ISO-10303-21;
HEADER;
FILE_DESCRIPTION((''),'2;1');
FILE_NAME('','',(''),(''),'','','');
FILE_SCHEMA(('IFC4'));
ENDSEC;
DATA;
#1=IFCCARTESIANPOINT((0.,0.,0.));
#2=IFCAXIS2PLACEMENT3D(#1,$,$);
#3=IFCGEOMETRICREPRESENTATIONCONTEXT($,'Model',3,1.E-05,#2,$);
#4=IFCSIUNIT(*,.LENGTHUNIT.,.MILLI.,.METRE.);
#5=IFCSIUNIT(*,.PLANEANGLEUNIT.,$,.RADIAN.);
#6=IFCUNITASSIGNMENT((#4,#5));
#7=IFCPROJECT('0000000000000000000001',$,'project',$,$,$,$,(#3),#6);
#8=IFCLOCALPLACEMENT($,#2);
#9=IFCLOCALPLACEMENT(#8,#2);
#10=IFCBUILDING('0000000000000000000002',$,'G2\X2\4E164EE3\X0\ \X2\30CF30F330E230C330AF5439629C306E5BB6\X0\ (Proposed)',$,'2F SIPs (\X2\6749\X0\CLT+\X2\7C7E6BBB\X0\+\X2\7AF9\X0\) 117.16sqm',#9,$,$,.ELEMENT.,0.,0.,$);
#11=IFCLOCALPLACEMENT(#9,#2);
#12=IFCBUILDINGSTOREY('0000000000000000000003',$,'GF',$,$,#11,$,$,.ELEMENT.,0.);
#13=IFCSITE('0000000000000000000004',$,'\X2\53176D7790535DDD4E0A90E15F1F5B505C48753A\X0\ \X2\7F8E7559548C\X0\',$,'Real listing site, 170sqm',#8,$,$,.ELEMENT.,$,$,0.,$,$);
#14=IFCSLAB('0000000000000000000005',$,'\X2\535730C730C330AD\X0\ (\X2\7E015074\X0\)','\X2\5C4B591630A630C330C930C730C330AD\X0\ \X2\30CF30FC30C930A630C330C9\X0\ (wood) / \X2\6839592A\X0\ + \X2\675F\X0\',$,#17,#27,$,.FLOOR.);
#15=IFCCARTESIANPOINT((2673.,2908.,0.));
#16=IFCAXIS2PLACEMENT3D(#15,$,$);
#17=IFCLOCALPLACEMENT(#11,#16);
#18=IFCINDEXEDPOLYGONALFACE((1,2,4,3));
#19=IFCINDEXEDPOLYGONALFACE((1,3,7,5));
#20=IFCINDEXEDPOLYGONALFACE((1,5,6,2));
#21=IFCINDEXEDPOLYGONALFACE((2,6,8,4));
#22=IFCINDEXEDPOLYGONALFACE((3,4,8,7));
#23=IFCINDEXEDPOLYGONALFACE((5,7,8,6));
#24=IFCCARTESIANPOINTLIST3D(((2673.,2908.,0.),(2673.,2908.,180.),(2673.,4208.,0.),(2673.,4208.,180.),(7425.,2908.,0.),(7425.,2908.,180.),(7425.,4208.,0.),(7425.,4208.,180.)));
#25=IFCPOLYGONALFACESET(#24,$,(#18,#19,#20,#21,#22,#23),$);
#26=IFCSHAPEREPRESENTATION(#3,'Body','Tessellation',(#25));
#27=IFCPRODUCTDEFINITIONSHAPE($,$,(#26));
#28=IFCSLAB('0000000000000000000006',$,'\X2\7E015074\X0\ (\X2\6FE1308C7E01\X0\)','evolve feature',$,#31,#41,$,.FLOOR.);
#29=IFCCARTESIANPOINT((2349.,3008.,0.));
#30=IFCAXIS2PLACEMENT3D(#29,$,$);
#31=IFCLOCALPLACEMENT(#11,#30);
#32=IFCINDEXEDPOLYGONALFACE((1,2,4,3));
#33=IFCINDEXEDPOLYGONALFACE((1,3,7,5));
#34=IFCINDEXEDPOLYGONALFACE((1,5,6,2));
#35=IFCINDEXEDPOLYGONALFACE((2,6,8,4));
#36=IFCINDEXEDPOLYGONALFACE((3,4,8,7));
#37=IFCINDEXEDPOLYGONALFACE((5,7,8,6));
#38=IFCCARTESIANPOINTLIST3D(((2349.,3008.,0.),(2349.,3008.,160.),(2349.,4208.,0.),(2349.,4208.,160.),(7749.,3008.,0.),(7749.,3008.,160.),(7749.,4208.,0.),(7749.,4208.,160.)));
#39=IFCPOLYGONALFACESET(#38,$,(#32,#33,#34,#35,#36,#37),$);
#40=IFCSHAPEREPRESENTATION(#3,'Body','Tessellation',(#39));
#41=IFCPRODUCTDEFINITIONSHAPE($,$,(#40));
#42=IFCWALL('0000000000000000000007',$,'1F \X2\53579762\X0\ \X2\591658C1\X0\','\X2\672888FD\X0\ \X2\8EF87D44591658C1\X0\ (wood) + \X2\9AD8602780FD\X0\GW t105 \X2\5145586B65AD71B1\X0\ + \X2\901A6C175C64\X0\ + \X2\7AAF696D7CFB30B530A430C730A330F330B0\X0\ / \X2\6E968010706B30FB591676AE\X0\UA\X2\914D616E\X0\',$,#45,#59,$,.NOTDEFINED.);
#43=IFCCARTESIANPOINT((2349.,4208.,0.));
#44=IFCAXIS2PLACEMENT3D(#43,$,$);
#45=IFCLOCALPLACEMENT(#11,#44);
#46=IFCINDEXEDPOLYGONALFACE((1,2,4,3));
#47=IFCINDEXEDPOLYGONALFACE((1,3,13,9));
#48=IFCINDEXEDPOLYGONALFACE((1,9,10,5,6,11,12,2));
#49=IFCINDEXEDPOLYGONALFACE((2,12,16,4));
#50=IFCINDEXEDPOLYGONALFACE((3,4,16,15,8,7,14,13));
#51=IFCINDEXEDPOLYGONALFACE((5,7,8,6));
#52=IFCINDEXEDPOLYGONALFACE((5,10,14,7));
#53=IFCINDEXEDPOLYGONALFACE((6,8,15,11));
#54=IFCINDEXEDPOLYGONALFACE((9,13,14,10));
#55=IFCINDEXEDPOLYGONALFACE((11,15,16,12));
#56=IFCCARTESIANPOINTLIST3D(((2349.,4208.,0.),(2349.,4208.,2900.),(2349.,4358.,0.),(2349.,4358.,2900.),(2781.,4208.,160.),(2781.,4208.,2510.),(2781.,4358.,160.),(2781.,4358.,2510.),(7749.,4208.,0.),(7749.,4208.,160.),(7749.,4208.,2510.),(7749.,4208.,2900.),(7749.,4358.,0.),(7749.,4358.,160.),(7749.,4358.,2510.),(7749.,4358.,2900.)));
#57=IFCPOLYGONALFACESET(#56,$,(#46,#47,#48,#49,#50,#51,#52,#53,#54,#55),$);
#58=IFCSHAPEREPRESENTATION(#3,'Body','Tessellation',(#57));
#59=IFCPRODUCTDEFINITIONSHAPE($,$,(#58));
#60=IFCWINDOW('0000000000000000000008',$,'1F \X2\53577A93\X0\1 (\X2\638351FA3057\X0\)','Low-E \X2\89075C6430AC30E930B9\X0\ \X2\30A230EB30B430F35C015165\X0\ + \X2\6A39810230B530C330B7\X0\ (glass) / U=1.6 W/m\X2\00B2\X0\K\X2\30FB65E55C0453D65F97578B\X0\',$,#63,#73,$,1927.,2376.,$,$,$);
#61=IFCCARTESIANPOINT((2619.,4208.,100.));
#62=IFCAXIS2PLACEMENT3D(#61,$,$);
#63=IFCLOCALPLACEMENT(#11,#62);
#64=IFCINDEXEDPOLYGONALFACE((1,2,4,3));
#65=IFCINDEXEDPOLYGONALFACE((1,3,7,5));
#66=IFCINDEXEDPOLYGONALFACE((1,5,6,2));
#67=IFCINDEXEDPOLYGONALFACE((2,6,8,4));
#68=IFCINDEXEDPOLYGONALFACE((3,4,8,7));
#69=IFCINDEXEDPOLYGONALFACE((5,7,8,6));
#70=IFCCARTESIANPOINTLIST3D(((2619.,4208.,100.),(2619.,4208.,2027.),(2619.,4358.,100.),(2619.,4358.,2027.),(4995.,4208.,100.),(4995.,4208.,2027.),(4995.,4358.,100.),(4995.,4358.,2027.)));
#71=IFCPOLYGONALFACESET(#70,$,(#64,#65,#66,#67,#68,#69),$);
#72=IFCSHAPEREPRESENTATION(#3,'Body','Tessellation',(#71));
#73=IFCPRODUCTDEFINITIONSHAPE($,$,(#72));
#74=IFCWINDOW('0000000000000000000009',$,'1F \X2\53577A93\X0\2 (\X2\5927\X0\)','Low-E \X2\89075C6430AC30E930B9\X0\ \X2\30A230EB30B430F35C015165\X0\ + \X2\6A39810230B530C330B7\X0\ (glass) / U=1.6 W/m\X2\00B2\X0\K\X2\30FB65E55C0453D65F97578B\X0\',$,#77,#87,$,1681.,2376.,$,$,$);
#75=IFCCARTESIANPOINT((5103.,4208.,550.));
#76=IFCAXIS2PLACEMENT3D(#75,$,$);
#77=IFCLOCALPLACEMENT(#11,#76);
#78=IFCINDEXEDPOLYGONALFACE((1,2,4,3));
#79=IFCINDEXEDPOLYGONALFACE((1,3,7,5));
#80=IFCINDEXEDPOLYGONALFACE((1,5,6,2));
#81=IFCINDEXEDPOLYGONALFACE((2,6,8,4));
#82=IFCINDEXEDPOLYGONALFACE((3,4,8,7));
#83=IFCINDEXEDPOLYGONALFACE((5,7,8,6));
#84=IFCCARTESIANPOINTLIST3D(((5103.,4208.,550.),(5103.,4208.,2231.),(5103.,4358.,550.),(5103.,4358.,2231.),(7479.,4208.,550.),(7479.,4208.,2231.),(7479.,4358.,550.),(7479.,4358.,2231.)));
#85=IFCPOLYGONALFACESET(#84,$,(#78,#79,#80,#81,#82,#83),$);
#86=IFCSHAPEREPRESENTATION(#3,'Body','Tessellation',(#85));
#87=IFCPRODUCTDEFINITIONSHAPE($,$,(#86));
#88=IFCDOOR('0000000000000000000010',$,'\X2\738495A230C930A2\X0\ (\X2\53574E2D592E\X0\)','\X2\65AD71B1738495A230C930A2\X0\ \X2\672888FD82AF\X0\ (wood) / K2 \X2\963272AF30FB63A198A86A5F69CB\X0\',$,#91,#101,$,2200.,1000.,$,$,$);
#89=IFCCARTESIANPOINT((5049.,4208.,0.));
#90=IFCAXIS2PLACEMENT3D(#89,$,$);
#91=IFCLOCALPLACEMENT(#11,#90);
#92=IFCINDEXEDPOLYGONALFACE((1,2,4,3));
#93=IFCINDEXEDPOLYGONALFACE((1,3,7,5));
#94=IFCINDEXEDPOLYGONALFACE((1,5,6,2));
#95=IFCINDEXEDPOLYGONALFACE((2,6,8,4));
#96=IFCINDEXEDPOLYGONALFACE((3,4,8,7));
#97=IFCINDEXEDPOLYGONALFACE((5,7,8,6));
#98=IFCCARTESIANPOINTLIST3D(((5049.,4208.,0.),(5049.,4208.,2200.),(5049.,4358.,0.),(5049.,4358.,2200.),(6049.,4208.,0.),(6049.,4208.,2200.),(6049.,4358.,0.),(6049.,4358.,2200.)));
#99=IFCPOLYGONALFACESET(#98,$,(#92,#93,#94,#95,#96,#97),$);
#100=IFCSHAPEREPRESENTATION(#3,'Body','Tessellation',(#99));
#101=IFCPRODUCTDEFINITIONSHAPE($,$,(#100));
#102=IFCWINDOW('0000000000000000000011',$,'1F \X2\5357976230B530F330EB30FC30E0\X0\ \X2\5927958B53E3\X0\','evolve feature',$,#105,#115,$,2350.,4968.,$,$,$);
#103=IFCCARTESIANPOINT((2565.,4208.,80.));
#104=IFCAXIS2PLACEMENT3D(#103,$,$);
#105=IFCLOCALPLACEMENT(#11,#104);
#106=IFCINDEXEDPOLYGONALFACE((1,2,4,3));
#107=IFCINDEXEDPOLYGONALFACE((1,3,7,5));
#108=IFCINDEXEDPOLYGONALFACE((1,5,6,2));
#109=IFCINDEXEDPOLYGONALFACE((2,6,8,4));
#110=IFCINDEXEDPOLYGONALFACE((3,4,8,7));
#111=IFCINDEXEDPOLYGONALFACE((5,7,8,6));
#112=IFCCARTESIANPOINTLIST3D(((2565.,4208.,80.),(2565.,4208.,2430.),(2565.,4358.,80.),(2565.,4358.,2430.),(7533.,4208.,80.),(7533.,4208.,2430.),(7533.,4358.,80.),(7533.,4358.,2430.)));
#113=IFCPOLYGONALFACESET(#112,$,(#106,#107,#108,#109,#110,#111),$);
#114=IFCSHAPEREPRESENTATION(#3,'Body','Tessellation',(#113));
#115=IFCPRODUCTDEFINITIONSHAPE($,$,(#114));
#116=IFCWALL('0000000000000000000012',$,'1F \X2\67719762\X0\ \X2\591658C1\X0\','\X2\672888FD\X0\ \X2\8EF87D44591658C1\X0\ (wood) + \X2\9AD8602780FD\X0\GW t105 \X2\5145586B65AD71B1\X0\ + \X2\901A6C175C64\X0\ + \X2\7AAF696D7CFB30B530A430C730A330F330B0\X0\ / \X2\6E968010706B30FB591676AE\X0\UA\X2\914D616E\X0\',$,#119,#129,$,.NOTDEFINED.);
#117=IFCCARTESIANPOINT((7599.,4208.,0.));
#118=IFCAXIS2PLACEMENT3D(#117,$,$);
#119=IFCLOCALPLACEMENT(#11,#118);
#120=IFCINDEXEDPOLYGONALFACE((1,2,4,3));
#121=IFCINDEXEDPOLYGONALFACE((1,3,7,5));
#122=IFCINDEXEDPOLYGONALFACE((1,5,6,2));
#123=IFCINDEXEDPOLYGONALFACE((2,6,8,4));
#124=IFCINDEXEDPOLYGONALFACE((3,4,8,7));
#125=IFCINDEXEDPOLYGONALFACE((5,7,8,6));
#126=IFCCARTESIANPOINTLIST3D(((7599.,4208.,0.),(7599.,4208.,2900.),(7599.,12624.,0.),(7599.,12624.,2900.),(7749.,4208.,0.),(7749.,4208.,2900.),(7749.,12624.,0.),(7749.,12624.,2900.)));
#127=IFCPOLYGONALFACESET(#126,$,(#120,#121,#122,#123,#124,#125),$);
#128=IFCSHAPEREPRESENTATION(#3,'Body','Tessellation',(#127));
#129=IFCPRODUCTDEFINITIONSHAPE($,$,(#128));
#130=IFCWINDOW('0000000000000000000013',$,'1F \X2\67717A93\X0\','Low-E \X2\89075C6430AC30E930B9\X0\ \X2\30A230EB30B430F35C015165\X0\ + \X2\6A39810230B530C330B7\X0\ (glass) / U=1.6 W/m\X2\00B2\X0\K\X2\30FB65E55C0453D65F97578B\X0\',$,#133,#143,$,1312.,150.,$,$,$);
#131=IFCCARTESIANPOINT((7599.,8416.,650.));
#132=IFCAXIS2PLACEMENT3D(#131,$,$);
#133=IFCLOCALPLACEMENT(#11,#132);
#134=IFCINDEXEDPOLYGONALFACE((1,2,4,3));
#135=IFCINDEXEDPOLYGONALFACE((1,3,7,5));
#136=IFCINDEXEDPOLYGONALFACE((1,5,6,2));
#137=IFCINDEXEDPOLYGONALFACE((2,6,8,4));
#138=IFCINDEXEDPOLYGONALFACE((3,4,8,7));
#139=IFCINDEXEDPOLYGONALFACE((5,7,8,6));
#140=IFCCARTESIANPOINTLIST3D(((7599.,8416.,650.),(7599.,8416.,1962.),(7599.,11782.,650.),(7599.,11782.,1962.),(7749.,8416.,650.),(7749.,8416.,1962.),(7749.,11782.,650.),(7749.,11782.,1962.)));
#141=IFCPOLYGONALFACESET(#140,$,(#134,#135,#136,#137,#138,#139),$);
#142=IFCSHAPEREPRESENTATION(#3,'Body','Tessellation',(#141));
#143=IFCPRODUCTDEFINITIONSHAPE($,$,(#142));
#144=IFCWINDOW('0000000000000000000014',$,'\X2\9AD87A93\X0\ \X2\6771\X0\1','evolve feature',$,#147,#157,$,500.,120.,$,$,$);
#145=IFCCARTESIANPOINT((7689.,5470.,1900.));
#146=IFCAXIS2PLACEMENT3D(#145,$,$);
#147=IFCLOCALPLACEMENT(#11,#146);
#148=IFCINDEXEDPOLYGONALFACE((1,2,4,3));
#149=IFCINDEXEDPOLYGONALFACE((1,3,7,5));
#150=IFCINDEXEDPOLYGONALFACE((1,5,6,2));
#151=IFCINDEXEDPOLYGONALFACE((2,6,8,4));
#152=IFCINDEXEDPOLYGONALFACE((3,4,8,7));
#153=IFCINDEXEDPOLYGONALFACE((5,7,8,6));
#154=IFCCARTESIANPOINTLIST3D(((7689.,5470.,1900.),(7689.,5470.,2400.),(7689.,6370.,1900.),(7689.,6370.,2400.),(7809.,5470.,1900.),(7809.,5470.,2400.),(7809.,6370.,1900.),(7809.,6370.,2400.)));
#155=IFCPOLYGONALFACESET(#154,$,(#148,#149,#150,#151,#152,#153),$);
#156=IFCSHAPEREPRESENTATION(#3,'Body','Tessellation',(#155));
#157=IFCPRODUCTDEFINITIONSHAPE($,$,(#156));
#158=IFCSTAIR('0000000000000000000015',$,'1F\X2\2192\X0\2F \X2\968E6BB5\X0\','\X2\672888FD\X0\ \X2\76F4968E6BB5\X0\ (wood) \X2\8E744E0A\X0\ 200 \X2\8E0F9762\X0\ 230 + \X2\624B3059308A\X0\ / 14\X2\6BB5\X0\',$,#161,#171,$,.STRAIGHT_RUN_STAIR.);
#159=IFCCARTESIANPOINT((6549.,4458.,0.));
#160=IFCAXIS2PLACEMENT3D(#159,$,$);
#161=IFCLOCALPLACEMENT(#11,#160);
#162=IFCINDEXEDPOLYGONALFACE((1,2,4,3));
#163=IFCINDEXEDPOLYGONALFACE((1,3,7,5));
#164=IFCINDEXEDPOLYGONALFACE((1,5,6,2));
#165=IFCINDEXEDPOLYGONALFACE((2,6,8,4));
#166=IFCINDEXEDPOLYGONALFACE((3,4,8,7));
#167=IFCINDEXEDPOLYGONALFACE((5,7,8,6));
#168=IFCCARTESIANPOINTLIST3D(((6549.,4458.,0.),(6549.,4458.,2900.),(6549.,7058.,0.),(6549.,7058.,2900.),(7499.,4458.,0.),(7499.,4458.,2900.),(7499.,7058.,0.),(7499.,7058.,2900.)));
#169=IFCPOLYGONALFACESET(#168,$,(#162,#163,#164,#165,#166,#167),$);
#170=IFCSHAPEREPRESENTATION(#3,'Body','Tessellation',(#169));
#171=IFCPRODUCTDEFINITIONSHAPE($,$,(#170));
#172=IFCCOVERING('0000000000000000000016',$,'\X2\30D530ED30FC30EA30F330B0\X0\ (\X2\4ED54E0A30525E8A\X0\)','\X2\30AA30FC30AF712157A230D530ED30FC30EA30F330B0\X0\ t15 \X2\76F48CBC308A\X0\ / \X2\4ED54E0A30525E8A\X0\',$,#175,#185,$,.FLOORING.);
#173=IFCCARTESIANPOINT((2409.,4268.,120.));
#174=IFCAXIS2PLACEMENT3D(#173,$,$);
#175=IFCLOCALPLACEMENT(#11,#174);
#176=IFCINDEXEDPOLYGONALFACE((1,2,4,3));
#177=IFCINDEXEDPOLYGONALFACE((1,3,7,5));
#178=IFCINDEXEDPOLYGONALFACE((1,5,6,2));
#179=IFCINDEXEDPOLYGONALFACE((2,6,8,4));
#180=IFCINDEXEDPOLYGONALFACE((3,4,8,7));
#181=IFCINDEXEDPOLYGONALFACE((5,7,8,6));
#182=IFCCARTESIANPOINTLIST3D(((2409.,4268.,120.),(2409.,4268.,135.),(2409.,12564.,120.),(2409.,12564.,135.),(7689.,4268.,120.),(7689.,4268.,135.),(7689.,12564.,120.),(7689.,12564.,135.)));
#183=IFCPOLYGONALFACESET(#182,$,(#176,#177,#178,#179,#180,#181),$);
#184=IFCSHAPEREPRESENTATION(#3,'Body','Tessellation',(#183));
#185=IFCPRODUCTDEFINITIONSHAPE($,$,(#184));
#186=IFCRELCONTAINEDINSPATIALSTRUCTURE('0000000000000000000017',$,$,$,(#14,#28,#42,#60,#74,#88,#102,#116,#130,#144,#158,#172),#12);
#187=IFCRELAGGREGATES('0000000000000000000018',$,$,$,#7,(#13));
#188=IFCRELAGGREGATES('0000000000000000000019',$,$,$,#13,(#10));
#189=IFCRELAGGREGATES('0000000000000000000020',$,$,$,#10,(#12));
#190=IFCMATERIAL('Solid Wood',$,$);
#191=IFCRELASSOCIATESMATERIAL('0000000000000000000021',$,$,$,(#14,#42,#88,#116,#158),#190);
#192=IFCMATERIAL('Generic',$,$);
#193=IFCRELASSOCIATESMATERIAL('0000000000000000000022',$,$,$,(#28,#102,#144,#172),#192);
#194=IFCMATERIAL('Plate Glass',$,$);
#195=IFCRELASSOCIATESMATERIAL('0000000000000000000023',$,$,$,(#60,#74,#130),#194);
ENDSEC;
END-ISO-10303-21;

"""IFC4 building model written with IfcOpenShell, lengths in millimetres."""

from ifc_helpers import new_model, si_unit, frame, frame_2d, origin, place, context, project, spatial, rectangle, extrude, material, element, fill, save


model = new_model("IFC4")

# Units and contexts
model_context = context("Model", 3, precision=1e-05, world=origin())
ifc_project = project(units=[si_unit("LENGTHUNIT", "METRE", prefix="MILLI"), si_unit("PLANEANGLEUNIT", "RADIAN")], contexts=[model_context])

# Site, building, storey
site_placement = place(None, origin())
site = spatial("IfcSite", under=ifc_project, at=site_placement, Name="北海道川上郡弟子屈町 美留和", ObjectType="Real listing site, 170sqm", CompositionType="ELEMENT", RefElevation=0.0)
building_placement = place(site_placement, origin())
building = spatial("IfcBuilding", under=site, at=building_placement, Name="G2世代 ハンモック吹抜の家 (Proposed)", ObjectType="2F SIPs (杉CLT+籾殻+竹) 117.16sqm", CompositionType="ELEMENT", ElevationOfRefHeight=0.0, ElevationOfTerrain=0.0)
storey_placement = place(building_placement, origin())
storey = spatial("IfcBuildingStorey", under=building, at=storey_placement, Name="GF", CompositionType="ELEMENT", Elevation=0.0)

# Slabs
ifc_material_1 = material(Name="Solid Wood")
slab_1_placement = place(storey_placement, frame((2673.0, 2908.0, 0.0)))
element("IfcSlab", 1, at=slab_1_placement, inside=storey, material=ifc_material_1, Name="南デッキ (縁側)", Description="屋外ウッドデッキ ハードウッド (wood) / 根太 + 束", PredefinedType="FLOOR", context=model_context, shape_type="SweptSolid", body=[
    extrude(rectangle(XDim=4752.0, YDim=1300.0, at=frame_2d((2376.0, 650.0))), frame((2673.0, 2908.0, 0.0)), (0.0, 0.0, 1.0), 180.0),
])
ifc_material_2 = material(Name="Generic")
slab_2_placement = place(storey_placement, frame((2349.0, 3008.0, 0.0)))
element("IfcSlab", 2, at=slab_2_placement, inside=storey, material=ifc_material_2, Name="縁側 (濡れ縁)", Description="evolve feature", PredefinedType="FLOOR", context=model_context, shape_type="SweptSolid", body=[
    extrude(rectangle(XDim=5400.0, YDim=1200.0, at=frame_2d((2700.0, 600.0))), frame((2349.0, 3008.0, 0.0)), (0.0, 0.0, 1.0), 160.0),
])

# Wall, openings, windows, door
wall_1_placement = place(storey_placement, frame((2349.0, 4208.0, 0.0)))
wall_1 = element("IfcWall", 3, at=wall_1_placement, inside=storey, material=ifc_material_1, Name="1F 南面 外壁", Description="木製 軸組外壁 (wood) + 高性能GW t105 充填断熱 + 通気層 + 窯業系サイディング / 準耐火・外皮UA配慮", PredefinedType="NOTDEFINED", context=model_context, shape_type="SweptSolid", body=[
    extrude(rectangle(XDim=5400.0, YDim=150.0, at=frame_2d((2700.0, 75.0))), frame((2349.0, 4208.0, 0.0)), (0.0, 0.0, 1.0), 2900.0),
])
opening_1_placement = place(storey_placement, frame((2619.0, 4208.0, 100.0)))
opening_1 = element("IfcOpeningElement", 4, at=opening_1_placement, cuts=wall_1, PredefinedType="NOTDEFINED", context=model_context, shape_type="SweptSolid", body=[
    extrude(rectangle(XDim=2376.0, YDim=150.0, at=frame_2d((1188.0, 75.0))), frame((2619.0, 4208.0, 100.0)), (0.0, 0.0, 1.0), 1927.0),
])
opening_2_placement = place(storey_placement, frame((5103.0, 4208.0, 550.0)))
opening_2 = element("IfcOpeningElement", 5, at=opening_2_placement, cuts=wall_1, PredefinedType="NOTDEFINED", context=model_context, shape_type="SweptSolid", body=[
    extrude(rectangle(XDim=2376.0, YDim=150.0, at=frame_2d((1188.0, 75.0))), frame((5103.0, 4208.0, 550.0)), (0.0, 0.0, 1.0), 1681.0),
])
opening_3_placement = place(storey_placement, frame((5049.0, 4208.0, 0.0)))
opening_3 = element("IfcOpeningElement", 6, at=opening_3_placement, cuts=wall_1, PredefinedType="NOTDEFINED", context=model_context, shape_type="SweptSolid", body=[
    extrude(rectangle(XDim=1000.0, YDim=150.0, at=frame_2d((500.0, 75.0))), frame((5049.0, 4208.0, 0.0)), (0.0, 0.0, 1.0), 2200.0),
])
opening_4_placement = place(storey_placement, frame((2565.0, 4208.0, 80.0)))
opening_4 = element("IfcOpeningElement", 7, at=opening_4_placement, cuts=wall_1, PredefinedType="NOTDEFINED", context=model_context, shape_type="SweptSolid", body=[
    extrude(rectangle(XDim=4968.0, YDim=150.0, at=frame_2d((2484.0, 75.0))), frame((2565.0, 4208.0, 80.0)), (0.0, 0.0, 1.0), 2350.0),
])
ifc_material_3 = material(Name="Plate Glass")
window_1_placement = place(storey_placement, frame((2619.0, 4208.0, 100.0)))
window_1 = element("IfcWindow", 8, at=window_1_placement, inside=storey, material=ifc_material_3, Name="1F 南窓1 (掃出し)", Description="Low-E 複層ガラス アルゴン封入 + 樹脂サッシ (glass) / U=1.6 W/m²K・日射取得型", OverallHeight=1927.0, OverallWidth=2376.0, context=model_context, shape_type="SweptSolid", body=[
    extrude(rectangle(XDim=2376.0, YDim=150.0, at=frame_2d((1188.0, 75.0))), frame((2619.0, 4208.0, 100.0)), (0.0, 0.0, 1.0), 1927.0),
])
fill(opening_1, window_1)
window_2_placement = place(storey_placement, frame((5103.0, 4208.0, 550.0)))
window_2 = element("IfcWindow", 9, at=window_2_placement, inside=storey, material=ifc_material_3, Name="1F 南窓2 (大)", Description="Low-E 複層ガラス アルゴン封入 + 樹脂サッシ (glass) / U=1.6 W/m²K・日射取得型", OverallHeight=1681.0, OverallWidth=2376.0, context=model_context, shape_type="SweptSolid", body=[
    extrude(rectangle(XDim=2376.0, YDim=150.0, at=frame_2d((1188.0, 75.0))), frame((5103.0, 4208.0, 550.0)), (0.0, 0.0, 1.0), 1681.0),
])
fill(opening_2, window_2)
door_placement = place(storey_placement, frame((5049.0, 4208.0, 0.0)))
door = element("IfcDoor", 10, at=door_placement, inside=storey, material=ifc_material_1, Name="玄関ドア (南中央)", Description="断熱玄関ドア 木製芯 (wood) / K2 防犯・採風機構", OverallHeight=2200.0, OverallWidth=1000.0, context=model_context, shape_type="SweptSolid", body=[
    extrude(rectangle(XDim=1000.0, YDim=150.0, at=frame_2d((500.0, 75.0))), frame((5049.0, 4208.0, 0.0)), (0.0, 0.0, 1.0), 2200.0),
])
fill(opening_3, door)
window_3_placement = place(storey_placement, frame((2565.0, 4208.0, 80.0)))
window_3 = element("IfcWindow", 11, at=window_3_placement, inside=storey, material=ifc_material_2, Name="1F 南面サンルーム 大開口", Description="evolve feature", OverallHeight=2350.0, OverallWidth=4968.0, context=model_context, shape_type="SweptSolid", body=[
    extrude(rectangle(XDim=4968.0, YDim=150.0, at=frame_2d((2484.0, 75.0))), frame((2565.0, 4208.0, 80.0)), (0.0, 0.0, 1.0), 2350.0),
])
fill(opening_4, window_3)

# Wall, openings, windows
wall_2_placement = place(storey_placement, frame((7599.0, 4208.0, 0.0)))
wall_2 = element("IfcWall", 12, at=wall_2_placement, inside=storey, material=ifc_material_1, Name="1F 東面 外壁", Description="木製 軸組外壁 (wood) + 高性能GW t105 充填断熱 + 通気層 + 窯業系サイディング / 準耐火・外皮UA配慮", PredefinedType="NOTDEFINED", context=model_context, shape_type="SweptSolid", body=[
    extrude(rectangle(XDim=150.0, YDim=8416.0, at=frame_2d((75.0, 4208.0))), frame((7599.0, 4208.0, 0.0)), (0.0, 0.0, 1.0), 2900.0),
])
opening_5_placement = place(storey_placement, frame((7599.0, 8416.0, 650.0)))
opening_5 = element("IfcOpeningElement", 13, at=opening_5_placement, cuts=wall_2, PredefinedType="NOTDEFINED", context=model_context, shape_type="SweptSolid", body=[
    extrude(rectangle(XDim=150.0, YDim=3366.0, at=frame_2d((75.0, 1683.0))), frame((7599.0, 8416.0, 650.0)), (0.0, 0.0, 1.0), 1312.0),
])
opening_6_placement = place(storey_placement, frame((7689.0, 5470.0, 1900.0)))
opening_6 = element("IfcOpeningElement", 14, at=opening_6_placement, cuts=wall_2, PredefinedType="NOTDEFINED", context=model_context, shape_type="SweptSolid", body=[
    extrude(rectangle(XDim=120.0, YDim=900.0, at=frame_2d((60.0, 450.0))), frame((7689.0, 5470.0, 1900.0)), (0.0, 0.0, 1.0), 500.0),
])
window_4_placement = place(storey_placement, frame((7599.0, 8416.0, 650.0)))
window_4 = element("IfcWindow", 15, at=window_4_placement, inside=storey, material=ifc_material_3, Name="1F 東窓", Description="Low-E 複層ガラス アルゴン封入 + 樹脂サッシ (glass) / U=1.6 W/m²K・日射取得型", OverallHeight=1312.0, OverallWidth=150.0, context=model_context, shape_type="SweptSolid", body=[
    extrude(rectangle(XDim=150.0, YDim=3366.0, at=frame_2d((75.0, 1683.0))), frame((7599.0, 8416.0, 650.0)), (0.0, 0.0, 1.0), 1312.0),
])
fill(opening_5, window_4)
window_5_placement = place(storey_placement, frame((7689.0, 5470.0, 1900.0)))
window_5 = element("IfcWindow", 16, at=window_5_placement, inside=storey, material=ifc_material_2, Name="高窓 東1", Description="evolve feature", OverallHeight=500.0, OverallWidth=120.0, context=model_context, shape_type="SweptSolid", body=[
    extrude(rectangle(XDim=120.0, YDim=900.0, at=frame_2d((60.0, 450.0))), frame((7689.0, 5470.0, 1900.0)), (0.0, 0.0, 1.0), 500.0),
])
fill(opening_6, window_5)

# Stair
stair_placement = place(storey_placement, frame((6549.0, 4458.0, 0.0)))
element("IfcStair", 17, at=stair_placement, inside=storey, material=ifc_material_1, Name="1F→2F 階段", Description="木製 直階段 (wood) 蹴上 200 踏面 230 + 手すり / 14段", PredefinedType="STRAIGHT_RUN_STAIR", context=model_context, shape_type="SweptSolid", body=[
    extrude(rectangle(XDim=950.0, YDim=2600.0, at=frame_2d((475.0, 1300.0))), frame((6549.0, 4458.0, 0.0)), (0.0, 0.0, 1.0), 2900.0),
])

# Covering
covering_placement = place(storey_placement, frame((2409.0, 4268.0, 120.0)))
element("IfcCovering", 18, at=covering_placement, inside=storey, material=ifc_material_2, Name="フローリング (仕上げ床)", Description="オーク無垢フローリング t15 直貼り / 仕上げ床", PredefinedType="FLOORING", context=model_context, shape_type="SweptSolid", body=[
    extrude(rectangle(XDim=5280.0, YDim=8296.0, at=frame_2d((2640.0, 4148.0))), frame((2409.0, 4268.0, 120.0)), (0.0, 0.0, 1.0), 15.0),
])

save(model, "model.ifc")
